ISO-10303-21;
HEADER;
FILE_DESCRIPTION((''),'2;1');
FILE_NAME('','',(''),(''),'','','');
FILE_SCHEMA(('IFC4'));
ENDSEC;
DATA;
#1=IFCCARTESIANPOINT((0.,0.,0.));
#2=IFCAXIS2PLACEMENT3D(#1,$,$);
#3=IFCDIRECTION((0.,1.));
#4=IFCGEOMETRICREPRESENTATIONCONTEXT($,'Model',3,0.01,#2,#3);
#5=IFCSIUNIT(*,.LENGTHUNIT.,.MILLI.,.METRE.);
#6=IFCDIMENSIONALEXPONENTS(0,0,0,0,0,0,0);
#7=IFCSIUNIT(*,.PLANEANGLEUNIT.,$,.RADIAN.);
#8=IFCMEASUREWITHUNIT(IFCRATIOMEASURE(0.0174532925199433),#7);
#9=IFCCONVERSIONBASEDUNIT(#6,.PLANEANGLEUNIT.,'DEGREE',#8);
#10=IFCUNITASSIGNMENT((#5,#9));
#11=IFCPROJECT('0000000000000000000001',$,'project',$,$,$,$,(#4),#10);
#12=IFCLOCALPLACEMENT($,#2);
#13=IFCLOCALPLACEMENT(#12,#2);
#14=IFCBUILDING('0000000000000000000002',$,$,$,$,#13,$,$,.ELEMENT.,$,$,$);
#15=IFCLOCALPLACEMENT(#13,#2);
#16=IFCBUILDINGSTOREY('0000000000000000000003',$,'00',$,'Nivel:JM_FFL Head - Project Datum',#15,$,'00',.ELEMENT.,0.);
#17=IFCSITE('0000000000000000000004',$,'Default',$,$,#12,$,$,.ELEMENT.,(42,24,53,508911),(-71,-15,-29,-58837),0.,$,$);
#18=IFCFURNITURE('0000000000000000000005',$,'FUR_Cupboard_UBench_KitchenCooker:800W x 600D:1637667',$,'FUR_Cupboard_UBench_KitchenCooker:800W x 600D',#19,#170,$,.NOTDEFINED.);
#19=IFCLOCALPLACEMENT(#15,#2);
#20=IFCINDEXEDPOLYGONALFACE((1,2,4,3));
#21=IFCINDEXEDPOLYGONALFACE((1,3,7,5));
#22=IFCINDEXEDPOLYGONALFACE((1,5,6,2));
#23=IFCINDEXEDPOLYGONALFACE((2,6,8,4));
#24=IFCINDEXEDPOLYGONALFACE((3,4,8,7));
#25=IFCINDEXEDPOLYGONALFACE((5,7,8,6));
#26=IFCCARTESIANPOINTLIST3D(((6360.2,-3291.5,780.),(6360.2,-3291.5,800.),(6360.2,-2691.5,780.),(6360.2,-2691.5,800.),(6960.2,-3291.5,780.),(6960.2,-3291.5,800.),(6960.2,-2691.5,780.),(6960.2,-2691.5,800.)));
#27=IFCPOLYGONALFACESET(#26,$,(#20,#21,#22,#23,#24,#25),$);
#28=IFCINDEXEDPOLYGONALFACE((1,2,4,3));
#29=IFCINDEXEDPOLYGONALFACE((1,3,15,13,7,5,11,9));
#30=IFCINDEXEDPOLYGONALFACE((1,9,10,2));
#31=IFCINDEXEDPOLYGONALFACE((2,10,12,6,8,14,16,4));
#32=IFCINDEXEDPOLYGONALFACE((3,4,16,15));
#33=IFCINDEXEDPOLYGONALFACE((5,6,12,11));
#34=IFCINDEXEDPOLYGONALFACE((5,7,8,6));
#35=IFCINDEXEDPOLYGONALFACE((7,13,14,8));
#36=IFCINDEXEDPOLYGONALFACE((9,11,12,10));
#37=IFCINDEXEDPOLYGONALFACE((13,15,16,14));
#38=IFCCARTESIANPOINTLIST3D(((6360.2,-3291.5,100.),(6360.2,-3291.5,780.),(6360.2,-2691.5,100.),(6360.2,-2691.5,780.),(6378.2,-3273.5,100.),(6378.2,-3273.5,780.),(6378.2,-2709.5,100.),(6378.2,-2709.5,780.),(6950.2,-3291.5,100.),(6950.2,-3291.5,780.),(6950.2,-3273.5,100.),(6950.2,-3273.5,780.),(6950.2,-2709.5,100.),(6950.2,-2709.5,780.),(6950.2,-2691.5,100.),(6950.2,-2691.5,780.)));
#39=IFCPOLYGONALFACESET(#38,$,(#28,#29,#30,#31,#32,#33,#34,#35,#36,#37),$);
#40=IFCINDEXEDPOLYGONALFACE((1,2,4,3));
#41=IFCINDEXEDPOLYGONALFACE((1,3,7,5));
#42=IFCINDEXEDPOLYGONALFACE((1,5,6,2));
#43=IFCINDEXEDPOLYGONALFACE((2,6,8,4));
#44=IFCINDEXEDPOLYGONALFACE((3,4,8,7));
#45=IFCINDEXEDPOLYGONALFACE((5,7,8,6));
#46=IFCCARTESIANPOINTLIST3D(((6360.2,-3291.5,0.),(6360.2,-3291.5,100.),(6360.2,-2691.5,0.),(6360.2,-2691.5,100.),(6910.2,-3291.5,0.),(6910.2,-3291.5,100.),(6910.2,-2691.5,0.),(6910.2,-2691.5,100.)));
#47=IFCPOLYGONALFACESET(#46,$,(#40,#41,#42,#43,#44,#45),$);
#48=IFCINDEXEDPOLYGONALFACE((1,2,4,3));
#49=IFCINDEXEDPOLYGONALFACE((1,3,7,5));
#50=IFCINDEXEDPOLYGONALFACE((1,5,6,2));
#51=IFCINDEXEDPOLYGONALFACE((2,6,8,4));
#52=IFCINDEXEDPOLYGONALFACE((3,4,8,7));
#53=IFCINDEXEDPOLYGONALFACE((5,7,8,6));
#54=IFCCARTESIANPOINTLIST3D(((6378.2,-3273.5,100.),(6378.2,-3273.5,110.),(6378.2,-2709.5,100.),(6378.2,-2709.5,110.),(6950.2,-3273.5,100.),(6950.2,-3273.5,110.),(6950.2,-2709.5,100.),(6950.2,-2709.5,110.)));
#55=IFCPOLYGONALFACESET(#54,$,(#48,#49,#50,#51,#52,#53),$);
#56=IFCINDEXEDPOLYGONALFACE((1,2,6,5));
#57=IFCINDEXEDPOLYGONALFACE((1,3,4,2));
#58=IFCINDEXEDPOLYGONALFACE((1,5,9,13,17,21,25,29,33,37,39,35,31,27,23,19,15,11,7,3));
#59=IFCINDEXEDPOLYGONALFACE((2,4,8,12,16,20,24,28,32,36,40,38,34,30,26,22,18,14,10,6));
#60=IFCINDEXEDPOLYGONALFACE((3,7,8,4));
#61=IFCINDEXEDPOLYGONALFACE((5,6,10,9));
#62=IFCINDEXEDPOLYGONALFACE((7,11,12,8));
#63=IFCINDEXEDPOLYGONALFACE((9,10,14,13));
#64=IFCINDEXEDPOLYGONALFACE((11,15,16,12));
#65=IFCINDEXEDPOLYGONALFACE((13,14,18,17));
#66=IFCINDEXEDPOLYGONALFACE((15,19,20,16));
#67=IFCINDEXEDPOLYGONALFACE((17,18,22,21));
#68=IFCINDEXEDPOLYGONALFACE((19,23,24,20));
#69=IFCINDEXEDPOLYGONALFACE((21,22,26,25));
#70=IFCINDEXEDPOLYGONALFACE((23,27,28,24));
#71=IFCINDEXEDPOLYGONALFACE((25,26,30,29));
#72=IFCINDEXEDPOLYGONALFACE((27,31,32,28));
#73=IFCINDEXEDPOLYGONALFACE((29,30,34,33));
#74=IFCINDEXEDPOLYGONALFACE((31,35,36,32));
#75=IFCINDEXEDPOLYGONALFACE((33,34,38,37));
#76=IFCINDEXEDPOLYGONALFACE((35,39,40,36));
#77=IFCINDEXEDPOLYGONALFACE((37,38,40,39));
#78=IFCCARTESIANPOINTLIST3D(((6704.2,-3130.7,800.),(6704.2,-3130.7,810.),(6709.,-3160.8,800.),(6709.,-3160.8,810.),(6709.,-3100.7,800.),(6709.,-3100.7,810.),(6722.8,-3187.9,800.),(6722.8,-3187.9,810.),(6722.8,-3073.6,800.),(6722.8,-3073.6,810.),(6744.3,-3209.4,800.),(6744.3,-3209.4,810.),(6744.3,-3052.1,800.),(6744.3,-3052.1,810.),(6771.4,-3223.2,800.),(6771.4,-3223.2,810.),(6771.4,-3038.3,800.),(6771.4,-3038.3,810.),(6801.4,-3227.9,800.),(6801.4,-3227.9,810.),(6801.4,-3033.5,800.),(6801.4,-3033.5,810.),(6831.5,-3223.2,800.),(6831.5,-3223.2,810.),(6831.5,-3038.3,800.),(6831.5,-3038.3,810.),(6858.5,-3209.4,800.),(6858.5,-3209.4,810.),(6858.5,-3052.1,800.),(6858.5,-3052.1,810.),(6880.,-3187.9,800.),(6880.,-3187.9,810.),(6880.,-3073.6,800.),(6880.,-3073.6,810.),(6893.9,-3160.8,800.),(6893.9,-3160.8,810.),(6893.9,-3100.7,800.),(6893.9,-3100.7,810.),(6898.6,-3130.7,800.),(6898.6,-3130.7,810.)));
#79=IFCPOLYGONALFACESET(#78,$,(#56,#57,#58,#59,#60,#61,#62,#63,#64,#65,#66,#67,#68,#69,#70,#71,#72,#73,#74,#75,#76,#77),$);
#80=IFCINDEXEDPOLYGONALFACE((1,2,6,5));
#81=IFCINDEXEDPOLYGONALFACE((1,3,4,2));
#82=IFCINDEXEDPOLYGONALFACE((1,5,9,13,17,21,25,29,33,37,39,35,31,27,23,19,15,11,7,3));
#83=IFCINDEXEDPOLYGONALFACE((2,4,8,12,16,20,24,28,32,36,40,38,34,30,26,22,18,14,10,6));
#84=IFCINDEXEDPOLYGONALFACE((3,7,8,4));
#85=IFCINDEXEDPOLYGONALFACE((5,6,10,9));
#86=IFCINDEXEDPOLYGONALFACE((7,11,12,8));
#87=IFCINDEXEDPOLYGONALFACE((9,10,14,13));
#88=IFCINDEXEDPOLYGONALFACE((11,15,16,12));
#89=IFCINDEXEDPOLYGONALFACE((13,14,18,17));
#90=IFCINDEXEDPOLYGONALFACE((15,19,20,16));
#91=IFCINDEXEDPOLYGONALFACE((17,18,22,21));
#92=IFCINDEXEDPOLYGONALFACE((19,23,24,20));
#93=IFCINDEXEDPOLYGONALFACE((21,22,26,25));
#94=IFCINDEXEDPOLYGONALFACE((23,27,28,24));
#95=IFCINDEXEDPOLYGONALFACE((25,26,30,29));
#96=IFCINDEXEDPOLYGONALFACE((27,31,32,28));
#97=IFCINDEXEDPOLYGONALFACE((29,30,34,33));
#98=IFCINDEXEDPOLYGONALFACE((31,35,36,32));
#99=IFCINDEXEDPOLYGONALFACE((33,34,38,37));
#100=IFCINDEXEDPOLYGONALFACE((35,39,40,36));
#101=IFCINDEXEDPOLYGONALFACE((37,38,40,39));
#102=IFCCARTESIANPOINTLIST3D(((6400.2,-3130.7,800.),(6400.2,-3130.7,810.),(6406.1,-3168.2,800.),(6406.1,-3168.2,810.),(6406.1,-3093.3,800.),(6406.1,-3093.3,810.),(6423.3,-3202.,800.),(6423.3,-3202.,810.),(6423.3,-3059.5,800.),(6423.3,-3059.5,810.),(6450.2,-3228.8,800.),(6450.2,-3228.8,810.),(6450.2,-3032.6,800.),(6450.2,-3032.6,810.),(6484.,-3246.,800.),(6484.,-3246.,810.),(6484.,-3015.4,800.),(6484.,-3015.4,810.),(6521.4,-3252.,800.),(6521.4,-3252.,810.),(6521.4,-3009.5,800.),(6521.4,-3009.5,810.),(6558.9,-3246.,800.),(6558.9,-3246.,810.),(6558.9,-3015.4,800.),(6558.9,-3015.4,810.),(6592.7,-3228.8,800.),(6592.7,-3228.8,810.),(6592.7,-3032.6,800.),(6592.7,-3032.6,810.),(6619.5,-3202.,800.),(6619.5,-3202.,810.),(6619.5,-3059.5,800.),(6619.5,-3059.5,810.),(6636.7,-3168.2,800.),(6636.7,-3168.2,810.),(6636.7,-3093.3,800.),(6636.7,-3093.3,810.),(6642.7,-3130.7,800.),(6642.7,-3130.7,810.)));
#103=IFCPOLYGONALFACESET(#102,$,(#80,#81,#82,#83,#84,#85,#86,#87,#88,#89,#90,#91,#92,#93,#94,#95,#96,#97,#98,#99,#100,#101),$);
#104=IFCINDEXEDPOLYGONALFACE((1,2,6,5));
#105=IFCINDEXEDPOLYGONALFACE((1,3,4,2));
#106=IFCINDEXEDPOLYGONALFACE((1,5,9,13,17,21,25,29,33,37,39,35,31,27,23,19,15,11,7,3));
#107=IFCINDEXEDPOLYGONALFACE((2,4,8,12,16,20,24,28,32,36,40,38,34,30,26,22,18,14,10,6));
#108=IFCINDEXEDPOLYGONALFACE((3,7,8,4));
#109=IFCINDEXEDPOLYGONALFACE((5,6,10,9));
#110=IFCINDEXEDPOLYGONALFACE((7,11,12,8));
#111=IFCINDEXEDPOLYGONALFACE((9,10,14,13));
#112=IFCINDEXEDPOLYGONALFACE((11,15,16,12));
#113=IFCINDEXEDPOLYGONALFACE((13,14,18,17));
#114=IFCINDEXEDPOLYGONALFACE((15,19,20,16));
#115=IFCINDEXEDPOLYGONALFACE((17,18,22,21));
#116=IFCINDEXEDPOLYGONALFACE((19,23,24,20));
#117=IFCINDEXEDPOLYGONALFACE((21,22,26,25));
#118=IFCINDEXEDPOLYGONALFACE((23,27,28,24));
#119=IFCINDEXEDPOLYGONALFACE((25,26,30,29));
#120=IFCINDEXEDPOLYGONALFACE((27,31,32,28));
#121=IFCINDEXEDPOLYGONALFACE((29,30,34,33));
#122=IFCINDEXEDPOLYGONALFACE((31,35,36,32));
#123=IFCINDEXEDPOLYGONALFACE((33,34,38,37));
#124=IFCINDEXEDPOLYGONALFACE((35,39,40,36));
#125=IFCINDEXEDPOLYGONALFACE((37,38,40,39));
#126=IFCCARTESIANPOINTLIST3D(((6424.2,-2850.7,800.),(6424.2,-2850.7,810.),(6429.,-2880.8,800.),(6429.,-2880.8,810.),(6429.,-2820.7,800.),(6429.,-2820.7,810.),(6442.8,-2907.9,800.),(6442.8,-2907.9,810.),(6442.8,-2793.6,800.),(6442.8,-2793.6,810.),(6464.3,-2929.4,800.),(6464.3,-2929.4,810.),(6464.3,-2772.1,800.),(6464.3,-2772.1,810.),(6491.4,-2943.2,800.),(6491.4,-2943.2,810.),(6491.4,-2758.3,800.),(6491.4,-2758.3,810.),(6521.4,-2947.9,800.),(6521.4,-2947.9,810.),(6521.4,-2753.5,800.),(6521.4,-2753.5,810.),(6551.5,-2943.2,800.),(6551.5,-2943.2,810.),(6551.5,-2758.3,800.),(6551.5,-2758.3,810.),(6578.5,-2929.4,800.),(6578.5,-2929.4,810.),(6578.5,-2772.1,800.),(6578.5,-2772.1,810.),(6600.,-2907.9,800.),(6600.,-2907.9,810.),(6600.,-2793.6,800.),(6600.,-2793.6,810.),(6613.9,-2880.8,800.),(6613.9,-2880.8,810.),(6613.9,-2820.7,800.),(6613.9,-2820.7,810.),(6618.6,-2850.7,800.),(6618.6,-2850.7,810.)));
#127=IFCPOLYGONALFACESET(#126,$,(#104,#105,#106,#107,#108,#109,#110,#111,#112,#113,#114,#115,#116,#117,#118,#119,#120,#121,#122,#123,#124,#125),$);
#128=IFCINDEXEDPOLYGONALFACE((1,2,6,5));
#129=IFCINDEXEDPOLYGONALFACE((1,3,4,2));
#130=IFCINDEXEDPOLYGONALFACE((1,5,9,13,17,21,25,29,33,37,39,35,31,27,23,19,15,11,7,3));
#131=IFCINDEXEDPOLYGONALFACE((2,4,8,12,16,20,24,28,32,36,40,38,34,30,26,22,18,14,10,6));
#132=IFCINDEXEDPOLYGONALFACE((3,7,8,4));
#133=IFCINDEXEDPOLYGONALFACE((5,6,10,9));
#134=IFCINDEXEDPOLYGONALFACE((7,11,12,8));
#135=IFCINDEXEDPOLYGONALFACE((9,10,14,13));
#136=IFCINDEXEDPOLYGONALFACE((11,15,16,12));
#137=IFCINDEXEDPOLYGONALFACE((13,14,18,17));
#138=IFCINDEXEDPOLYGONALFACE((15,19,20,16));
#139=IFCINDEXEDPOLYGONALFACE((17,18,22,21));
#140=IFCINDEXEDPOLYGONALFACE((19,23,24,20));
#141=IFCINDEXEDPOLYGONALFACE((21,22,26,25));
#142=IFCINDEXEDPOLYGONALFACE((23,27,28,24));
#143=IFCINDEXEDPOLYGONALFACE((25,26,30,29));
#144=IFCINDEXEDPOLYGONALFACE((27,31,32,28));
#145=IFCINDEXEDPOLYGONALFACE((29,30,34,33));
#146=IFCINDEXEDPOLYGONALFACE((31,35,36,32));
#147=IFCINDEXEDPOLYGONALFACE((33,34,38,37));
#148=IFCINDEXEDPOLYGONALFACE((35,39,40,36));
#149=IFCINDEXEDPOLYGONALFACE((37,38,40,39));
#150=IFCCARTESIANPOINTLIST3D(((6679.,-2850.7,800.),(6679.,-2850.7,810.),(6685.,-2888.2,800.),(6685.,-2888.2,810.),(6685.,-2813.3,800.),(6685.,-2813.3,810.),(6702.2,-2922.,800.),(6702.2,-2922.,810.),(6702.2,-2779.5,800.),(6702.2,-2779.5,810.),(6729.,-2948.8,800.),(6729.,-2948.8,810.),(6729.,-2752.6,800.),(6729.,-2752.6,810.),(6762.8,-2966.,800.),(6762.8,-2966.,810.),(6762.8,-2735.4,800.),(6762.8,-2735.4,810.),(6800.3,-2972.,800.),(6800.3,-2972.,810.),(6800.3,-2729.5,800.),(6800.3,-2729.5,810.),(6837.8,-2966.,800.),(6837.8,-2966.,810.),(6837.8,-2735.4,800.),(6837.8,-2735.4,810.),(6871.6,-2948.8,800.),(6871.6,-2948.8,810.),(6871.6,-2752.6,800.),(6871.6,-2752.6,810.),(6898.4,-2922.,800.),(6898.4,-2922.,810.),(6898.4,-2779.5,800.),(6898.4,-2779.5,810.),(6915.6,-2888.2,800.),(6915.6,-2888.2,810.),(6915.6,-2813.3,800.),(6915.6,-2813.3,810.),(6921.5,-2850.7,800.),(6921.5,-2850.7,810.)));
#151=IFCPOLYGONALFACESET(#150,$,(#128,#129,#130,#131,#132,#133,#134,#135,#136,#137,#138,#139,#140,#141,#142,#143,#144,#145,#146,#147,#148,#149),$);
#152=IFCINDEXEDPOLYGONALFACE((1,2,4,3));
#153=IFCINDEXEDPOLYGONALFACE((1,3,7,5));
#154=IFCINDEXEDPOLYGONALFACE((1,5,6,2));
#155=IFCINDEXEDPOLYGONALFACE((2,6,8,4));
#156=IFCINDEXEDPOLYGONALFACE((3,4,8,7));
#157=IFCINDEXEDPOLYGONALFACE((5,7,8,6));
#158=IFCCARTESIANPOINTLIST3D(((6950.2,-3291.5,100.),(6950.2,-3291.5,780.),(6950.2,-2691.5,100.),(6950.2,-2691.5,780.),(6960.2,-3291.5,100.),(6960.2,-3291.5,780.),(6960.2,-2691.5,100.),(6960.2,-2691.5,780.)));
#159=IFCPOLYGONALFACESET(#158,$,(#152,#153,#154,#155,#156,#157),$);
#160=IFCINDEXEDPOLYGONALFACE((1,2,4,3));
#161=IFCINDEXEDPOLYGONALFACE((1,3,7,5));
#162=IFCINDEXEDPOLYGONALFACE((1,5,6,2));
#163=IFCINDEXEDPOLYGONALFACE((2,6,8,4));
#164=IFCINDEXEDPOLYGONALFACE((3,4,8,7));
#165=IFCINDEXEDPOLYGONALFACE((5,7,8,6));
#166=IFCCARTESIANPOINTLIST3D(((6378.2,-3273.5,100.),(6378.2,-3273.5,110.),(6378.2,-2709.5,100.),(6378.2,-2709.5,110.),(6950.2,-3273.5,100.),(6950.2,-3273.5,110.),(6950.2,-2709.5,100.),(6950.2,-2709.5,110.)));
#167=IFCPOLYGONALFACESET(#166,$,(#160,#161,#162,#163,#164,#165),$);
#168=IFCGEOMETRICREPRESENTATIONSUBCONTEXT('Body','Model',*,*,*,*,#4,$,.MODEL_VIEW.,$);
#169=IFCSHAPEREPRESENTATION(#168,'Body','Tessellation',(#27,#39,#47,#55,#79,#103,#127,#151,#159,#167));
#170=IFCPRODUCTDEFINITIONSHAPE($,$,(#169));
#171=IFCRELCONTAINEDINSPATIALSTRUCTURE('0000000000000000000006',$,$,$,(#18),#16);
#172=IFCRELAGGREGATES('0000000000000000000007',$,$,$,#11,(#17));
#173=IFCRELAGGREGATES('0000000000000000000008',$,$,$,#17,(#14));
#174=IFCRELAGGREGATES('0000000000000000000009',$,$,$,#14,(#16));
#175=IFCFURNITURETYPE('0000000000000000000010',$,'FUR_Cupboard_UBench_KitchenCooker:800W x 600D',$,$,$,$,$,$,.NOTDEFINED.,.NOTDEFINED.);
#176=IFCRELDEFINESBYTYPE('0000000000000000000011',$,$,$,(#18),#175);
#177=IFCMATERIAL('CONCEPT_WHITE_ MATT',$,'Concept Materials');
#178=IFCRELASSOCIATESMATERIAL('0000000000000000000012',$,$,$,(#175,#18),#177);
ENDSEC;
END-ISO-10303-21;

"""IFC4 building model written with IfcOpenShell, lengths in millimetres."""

from ifc_helpers import new_model, entity, si_unit, converted_unit, direction, frame, origin, place, context, subcontext, project, spatial, indexed_curve, outline, extrude, source, transform, mapped, material, type_object, type_shapes, element, save


model = new_model("IFC4")

# Units and contexts
model_context = context("Model", 3, precision=0.01, world=origin(), true_north=direction((0.0, 1.0)))
body_context = subcontext(model_context, "Body", "Model", "MODEL_VIEW")
ifc_project = project(units=[si_unit("LENGTHUNIT", "METRE", prefix="MILLI"), converted_unit("PLANEANGLEUNIT", "DEGREE", entity("IfcRatioMeasure", 0.0174532925199433), si_unit("PLANEANGLEUNIT", "RADIAN"), dimensions=[0, 0, 0, 0, 0, 0, 0])], contexts=[model_context])

# Site, building, storey
site_placement = place(None, origin())
site = spatial("IfcSite", under=ifc_project, at=site_placement, Name="Default", CompositionType="ELEMENT", RefLatitude=(42, 24, 53, 508911), RefLongitude=(-71, -15, -29, -58837), RefElevation=0.0)
building_placement = place(site_placement, origin())
building = spatial("IfcBuilding", under=site, at=building_placement, CompositionType="ELEMENT")
storey_placement = place(building_placement, origin())
storey = spatial("IfcBuildingStorey", under=building, at=storey_placement, Name="00", ObjectType="Nivel:JM_FFL Head - Project Datum", LongName="00", CompositionType="ELEMENT", Elevation=0.0)

# Furniture
ifc_material_1 = material(Name="CONCEPT_WHITE_ MATT", Category="Concept Materials")
furniture_type_1 = type_object("IfcFurnitureType", Name="FUR_Cupboard_UBench_KitchenCooker:800W x 600D", AssemblyPlace="NOTDEFINED", PredefinedType="NOTDEFINED", material=ifc_material_1)
shared_shape_1 = source(origin(), body_context, "Body", "SweptSolid", [
    extrude(outline(indexed_curve([(-300.0, -300.0), (300.0, -300.0), (300.0, 300.0), (-300.0, 300.0), (-300.0, -300.0)], self_intersect=False)), frame((44.7, 300.0, 780.0), z_axis=(0.0, 0.0, 1.0), x_axis=(0.0, 1.0, 0.0)), (0.0, 0.0, 1.0), 20.0),
    extrude(outline(indexed_curve([(-299.5, -300.0), (290.5, -300.0), (290.5, -282.0), (-281.5, -282.0), (-281.5, 282.0), (290.5, 282.0), (290.5, 300.0), (-299.5, 300.0), (-299.5, -300.0)], self_intersect=False)), frame((44.7, 299.5, 100.0), z_axis=(0.0, 0.0, 1.0), x_axis=(0.0, 1.0, 0.0)), (0.0, 0.0, 1.0), 680.0),
    extrude(outline(indexed_curve([(-275.0, -300.0), (275.0, -300.0), (275.0, 300.0), (-275.0, 300.0), (-275.0, -300.0)], self_intersect=False)), frame((44.7, 275.0, 0.0), z_axis=(0.0, 0.0, 1.0), x_axis=(0.0, 1.0, 0.0)), (0.0, 0.0, 1.0), 100.0),
    extrude(outline(indexed_curve([(-286.0, -282.0), (286.0, -282.0), (286.0, 282.0), (-286.0, 282.0), (-286.0, -282.0)], self_intersect=False)), frame((44.7, 304.0, 100.0), z_axis=(0.0, 0.0, 1.0), x_axis=(0.0, 1.0, 0.0)), (0.0, 0.0, 1.0), 10.0),
    extrude(outline(indexed_curve([(97.2, 0.0), (92.4, 30.0), (78.6, 57.1), (57.1, 78.6), (30.0, 92.4), (0.0, 97.2), (-30.0, 92.4), (-57.1, 78.6), (-78.6, 57.1), (-92.4, 30.0), (-97.2, 0.0), (-92.4, -30.0), (-78.6, -57.1), (-57.1, -78.6), (-30.0, -92.4), (0.0, -97.2), (30.0, -92.4), (57.1, -78.6), (78.6, -57.1), (92.4, -30.0), (97.2, 0.0)], self_intersect=False)), frame((184.0, 441.3, 800.0)), (0.0, 0.0, 1.0), 10.0),
    extrude(outline(indexed_curve([(121.2, 0.0), (115.3, 37.5), (98.1, 71.3), (71.3, 98.1), (37.5, 115.3), (0.0, 121.2), (-37.5, 115.3), (-71.3, 98.1), (-98.1, 71.3), (-115.3, 37.5), (-121.2, 0.0), (-115.3, -37.5), (-98.1, -71.3), (-71.3, -98.1), (-37.5, -115.3), (0.0, -121.3), (37.5, -115.3), (71.3, -98.1), (98.1, -71.3), (115.3, -37.5), (121.2, 0.0)], self_intersect=False)), frame((184.0, 161.3, 800.0)), (0.0, 0.0, 1.0), 10.0),
    extrude(outline(indexed_curve([(97.2, 0.0), (92.4, 30.0), (78.6, 57.1), (57.1, 78.6), (30.0, 92.4), (0.0, 97.2), (-30.0, 92.4), (-57.1, 78.6), (-78.6, 57.1), (-92.4, 30.0), (-97.2, 0.0), (-92.4, -30.0), (-78.6, -57.1), (-57.1, -78.6), (-30.0, -92.4), (0.0, -97.2), (30.0, -92.4), (57.1, -78.6), (78.6, -57.1), (92.4, -30.0), (97.2, 0.0)], self_intersect=False)), frame((-96.0, 161.3, 800.0)), (0.0, 0.0, 1.0), 10.0),
    extrude(outline(indexed_curve([(121.2, 0.0), (115.3, 37.5), (98.1, 71.3), (71.3, 98.1), (37.5, 115.3), (0.0, 121.2), (-37.5, 115.3), (-71.3, 98.1), (-98.1, 71.3), (-115.3, 37.5), (-121.2, 0.0), (-115.3, -37.5), (-98.1, -71.3), (-71.3, -98.1), (-37.5, -115.3), (0.0, -121.3), (37.5, -115.3), (71.3, -98.1), (98.1, -71.3), (115.3, -37.5), (121.2, 0.0)], self_intersect=False)), frame((-96.0, 440.1, 800.0)), (0.0, 0.0, 1.0), 10.0),
    extrude(outline(indexed_curve([(-5.0, -300.0), (5.0, -300.0), (5.0, 300.0), (-5.0, 300.0), (-5.0, -300.0)], self_intersect=False)), frame((44.7, 595.0, 100.0), z_axis=(0.0, 0.0, 1.0), x_axis=(0.0, 1.0, 0.0)), (0.0, 0.0, 1.0), 680.0),
    extrude(outline(indexed_curve([(-286.0, -282.0), (286.0, -282.0), (286.0, 282.0), (-286.0, 282.0), (-286.0, -282.0)], self_intersect=False)), frame((44.7, 304.0, 100.0), z_axis=(0.0, 0.0, 1.0), x_axis=(0.0, 1.0, 0.0)), (0.0, 0.0, 1.0), 10.0),
])
type_shapes(furniture_type_1, [shared_shape_1])
furniture_1_placement = place(storey_placement, frame((6360.2, -2946.8, 0.0), z_axis=(0.0, 0.0, 1.0), x_axis=(0.0, -1.0, 0.0)))
element("IfcFurniture", 1, at=furniture_1_placement, inside=storey, type_object=furniture_type_1, material=ifc_material_1, Name="FUR_Cupboard_UBench_KitchenCooker:800W x 600D:1637667", ObjectType="FUR_Cupboard_UBench_KitchenCooker:800W x 600D", PredefinedType="NOTDEFINED", context=body_context, shape_type="MappedRepresentation", body=[
    mapped(shared_shape_1, transform((0.0, 0.0, 0.0), scale=1.0)),
])

save(model, "model.ifc")
